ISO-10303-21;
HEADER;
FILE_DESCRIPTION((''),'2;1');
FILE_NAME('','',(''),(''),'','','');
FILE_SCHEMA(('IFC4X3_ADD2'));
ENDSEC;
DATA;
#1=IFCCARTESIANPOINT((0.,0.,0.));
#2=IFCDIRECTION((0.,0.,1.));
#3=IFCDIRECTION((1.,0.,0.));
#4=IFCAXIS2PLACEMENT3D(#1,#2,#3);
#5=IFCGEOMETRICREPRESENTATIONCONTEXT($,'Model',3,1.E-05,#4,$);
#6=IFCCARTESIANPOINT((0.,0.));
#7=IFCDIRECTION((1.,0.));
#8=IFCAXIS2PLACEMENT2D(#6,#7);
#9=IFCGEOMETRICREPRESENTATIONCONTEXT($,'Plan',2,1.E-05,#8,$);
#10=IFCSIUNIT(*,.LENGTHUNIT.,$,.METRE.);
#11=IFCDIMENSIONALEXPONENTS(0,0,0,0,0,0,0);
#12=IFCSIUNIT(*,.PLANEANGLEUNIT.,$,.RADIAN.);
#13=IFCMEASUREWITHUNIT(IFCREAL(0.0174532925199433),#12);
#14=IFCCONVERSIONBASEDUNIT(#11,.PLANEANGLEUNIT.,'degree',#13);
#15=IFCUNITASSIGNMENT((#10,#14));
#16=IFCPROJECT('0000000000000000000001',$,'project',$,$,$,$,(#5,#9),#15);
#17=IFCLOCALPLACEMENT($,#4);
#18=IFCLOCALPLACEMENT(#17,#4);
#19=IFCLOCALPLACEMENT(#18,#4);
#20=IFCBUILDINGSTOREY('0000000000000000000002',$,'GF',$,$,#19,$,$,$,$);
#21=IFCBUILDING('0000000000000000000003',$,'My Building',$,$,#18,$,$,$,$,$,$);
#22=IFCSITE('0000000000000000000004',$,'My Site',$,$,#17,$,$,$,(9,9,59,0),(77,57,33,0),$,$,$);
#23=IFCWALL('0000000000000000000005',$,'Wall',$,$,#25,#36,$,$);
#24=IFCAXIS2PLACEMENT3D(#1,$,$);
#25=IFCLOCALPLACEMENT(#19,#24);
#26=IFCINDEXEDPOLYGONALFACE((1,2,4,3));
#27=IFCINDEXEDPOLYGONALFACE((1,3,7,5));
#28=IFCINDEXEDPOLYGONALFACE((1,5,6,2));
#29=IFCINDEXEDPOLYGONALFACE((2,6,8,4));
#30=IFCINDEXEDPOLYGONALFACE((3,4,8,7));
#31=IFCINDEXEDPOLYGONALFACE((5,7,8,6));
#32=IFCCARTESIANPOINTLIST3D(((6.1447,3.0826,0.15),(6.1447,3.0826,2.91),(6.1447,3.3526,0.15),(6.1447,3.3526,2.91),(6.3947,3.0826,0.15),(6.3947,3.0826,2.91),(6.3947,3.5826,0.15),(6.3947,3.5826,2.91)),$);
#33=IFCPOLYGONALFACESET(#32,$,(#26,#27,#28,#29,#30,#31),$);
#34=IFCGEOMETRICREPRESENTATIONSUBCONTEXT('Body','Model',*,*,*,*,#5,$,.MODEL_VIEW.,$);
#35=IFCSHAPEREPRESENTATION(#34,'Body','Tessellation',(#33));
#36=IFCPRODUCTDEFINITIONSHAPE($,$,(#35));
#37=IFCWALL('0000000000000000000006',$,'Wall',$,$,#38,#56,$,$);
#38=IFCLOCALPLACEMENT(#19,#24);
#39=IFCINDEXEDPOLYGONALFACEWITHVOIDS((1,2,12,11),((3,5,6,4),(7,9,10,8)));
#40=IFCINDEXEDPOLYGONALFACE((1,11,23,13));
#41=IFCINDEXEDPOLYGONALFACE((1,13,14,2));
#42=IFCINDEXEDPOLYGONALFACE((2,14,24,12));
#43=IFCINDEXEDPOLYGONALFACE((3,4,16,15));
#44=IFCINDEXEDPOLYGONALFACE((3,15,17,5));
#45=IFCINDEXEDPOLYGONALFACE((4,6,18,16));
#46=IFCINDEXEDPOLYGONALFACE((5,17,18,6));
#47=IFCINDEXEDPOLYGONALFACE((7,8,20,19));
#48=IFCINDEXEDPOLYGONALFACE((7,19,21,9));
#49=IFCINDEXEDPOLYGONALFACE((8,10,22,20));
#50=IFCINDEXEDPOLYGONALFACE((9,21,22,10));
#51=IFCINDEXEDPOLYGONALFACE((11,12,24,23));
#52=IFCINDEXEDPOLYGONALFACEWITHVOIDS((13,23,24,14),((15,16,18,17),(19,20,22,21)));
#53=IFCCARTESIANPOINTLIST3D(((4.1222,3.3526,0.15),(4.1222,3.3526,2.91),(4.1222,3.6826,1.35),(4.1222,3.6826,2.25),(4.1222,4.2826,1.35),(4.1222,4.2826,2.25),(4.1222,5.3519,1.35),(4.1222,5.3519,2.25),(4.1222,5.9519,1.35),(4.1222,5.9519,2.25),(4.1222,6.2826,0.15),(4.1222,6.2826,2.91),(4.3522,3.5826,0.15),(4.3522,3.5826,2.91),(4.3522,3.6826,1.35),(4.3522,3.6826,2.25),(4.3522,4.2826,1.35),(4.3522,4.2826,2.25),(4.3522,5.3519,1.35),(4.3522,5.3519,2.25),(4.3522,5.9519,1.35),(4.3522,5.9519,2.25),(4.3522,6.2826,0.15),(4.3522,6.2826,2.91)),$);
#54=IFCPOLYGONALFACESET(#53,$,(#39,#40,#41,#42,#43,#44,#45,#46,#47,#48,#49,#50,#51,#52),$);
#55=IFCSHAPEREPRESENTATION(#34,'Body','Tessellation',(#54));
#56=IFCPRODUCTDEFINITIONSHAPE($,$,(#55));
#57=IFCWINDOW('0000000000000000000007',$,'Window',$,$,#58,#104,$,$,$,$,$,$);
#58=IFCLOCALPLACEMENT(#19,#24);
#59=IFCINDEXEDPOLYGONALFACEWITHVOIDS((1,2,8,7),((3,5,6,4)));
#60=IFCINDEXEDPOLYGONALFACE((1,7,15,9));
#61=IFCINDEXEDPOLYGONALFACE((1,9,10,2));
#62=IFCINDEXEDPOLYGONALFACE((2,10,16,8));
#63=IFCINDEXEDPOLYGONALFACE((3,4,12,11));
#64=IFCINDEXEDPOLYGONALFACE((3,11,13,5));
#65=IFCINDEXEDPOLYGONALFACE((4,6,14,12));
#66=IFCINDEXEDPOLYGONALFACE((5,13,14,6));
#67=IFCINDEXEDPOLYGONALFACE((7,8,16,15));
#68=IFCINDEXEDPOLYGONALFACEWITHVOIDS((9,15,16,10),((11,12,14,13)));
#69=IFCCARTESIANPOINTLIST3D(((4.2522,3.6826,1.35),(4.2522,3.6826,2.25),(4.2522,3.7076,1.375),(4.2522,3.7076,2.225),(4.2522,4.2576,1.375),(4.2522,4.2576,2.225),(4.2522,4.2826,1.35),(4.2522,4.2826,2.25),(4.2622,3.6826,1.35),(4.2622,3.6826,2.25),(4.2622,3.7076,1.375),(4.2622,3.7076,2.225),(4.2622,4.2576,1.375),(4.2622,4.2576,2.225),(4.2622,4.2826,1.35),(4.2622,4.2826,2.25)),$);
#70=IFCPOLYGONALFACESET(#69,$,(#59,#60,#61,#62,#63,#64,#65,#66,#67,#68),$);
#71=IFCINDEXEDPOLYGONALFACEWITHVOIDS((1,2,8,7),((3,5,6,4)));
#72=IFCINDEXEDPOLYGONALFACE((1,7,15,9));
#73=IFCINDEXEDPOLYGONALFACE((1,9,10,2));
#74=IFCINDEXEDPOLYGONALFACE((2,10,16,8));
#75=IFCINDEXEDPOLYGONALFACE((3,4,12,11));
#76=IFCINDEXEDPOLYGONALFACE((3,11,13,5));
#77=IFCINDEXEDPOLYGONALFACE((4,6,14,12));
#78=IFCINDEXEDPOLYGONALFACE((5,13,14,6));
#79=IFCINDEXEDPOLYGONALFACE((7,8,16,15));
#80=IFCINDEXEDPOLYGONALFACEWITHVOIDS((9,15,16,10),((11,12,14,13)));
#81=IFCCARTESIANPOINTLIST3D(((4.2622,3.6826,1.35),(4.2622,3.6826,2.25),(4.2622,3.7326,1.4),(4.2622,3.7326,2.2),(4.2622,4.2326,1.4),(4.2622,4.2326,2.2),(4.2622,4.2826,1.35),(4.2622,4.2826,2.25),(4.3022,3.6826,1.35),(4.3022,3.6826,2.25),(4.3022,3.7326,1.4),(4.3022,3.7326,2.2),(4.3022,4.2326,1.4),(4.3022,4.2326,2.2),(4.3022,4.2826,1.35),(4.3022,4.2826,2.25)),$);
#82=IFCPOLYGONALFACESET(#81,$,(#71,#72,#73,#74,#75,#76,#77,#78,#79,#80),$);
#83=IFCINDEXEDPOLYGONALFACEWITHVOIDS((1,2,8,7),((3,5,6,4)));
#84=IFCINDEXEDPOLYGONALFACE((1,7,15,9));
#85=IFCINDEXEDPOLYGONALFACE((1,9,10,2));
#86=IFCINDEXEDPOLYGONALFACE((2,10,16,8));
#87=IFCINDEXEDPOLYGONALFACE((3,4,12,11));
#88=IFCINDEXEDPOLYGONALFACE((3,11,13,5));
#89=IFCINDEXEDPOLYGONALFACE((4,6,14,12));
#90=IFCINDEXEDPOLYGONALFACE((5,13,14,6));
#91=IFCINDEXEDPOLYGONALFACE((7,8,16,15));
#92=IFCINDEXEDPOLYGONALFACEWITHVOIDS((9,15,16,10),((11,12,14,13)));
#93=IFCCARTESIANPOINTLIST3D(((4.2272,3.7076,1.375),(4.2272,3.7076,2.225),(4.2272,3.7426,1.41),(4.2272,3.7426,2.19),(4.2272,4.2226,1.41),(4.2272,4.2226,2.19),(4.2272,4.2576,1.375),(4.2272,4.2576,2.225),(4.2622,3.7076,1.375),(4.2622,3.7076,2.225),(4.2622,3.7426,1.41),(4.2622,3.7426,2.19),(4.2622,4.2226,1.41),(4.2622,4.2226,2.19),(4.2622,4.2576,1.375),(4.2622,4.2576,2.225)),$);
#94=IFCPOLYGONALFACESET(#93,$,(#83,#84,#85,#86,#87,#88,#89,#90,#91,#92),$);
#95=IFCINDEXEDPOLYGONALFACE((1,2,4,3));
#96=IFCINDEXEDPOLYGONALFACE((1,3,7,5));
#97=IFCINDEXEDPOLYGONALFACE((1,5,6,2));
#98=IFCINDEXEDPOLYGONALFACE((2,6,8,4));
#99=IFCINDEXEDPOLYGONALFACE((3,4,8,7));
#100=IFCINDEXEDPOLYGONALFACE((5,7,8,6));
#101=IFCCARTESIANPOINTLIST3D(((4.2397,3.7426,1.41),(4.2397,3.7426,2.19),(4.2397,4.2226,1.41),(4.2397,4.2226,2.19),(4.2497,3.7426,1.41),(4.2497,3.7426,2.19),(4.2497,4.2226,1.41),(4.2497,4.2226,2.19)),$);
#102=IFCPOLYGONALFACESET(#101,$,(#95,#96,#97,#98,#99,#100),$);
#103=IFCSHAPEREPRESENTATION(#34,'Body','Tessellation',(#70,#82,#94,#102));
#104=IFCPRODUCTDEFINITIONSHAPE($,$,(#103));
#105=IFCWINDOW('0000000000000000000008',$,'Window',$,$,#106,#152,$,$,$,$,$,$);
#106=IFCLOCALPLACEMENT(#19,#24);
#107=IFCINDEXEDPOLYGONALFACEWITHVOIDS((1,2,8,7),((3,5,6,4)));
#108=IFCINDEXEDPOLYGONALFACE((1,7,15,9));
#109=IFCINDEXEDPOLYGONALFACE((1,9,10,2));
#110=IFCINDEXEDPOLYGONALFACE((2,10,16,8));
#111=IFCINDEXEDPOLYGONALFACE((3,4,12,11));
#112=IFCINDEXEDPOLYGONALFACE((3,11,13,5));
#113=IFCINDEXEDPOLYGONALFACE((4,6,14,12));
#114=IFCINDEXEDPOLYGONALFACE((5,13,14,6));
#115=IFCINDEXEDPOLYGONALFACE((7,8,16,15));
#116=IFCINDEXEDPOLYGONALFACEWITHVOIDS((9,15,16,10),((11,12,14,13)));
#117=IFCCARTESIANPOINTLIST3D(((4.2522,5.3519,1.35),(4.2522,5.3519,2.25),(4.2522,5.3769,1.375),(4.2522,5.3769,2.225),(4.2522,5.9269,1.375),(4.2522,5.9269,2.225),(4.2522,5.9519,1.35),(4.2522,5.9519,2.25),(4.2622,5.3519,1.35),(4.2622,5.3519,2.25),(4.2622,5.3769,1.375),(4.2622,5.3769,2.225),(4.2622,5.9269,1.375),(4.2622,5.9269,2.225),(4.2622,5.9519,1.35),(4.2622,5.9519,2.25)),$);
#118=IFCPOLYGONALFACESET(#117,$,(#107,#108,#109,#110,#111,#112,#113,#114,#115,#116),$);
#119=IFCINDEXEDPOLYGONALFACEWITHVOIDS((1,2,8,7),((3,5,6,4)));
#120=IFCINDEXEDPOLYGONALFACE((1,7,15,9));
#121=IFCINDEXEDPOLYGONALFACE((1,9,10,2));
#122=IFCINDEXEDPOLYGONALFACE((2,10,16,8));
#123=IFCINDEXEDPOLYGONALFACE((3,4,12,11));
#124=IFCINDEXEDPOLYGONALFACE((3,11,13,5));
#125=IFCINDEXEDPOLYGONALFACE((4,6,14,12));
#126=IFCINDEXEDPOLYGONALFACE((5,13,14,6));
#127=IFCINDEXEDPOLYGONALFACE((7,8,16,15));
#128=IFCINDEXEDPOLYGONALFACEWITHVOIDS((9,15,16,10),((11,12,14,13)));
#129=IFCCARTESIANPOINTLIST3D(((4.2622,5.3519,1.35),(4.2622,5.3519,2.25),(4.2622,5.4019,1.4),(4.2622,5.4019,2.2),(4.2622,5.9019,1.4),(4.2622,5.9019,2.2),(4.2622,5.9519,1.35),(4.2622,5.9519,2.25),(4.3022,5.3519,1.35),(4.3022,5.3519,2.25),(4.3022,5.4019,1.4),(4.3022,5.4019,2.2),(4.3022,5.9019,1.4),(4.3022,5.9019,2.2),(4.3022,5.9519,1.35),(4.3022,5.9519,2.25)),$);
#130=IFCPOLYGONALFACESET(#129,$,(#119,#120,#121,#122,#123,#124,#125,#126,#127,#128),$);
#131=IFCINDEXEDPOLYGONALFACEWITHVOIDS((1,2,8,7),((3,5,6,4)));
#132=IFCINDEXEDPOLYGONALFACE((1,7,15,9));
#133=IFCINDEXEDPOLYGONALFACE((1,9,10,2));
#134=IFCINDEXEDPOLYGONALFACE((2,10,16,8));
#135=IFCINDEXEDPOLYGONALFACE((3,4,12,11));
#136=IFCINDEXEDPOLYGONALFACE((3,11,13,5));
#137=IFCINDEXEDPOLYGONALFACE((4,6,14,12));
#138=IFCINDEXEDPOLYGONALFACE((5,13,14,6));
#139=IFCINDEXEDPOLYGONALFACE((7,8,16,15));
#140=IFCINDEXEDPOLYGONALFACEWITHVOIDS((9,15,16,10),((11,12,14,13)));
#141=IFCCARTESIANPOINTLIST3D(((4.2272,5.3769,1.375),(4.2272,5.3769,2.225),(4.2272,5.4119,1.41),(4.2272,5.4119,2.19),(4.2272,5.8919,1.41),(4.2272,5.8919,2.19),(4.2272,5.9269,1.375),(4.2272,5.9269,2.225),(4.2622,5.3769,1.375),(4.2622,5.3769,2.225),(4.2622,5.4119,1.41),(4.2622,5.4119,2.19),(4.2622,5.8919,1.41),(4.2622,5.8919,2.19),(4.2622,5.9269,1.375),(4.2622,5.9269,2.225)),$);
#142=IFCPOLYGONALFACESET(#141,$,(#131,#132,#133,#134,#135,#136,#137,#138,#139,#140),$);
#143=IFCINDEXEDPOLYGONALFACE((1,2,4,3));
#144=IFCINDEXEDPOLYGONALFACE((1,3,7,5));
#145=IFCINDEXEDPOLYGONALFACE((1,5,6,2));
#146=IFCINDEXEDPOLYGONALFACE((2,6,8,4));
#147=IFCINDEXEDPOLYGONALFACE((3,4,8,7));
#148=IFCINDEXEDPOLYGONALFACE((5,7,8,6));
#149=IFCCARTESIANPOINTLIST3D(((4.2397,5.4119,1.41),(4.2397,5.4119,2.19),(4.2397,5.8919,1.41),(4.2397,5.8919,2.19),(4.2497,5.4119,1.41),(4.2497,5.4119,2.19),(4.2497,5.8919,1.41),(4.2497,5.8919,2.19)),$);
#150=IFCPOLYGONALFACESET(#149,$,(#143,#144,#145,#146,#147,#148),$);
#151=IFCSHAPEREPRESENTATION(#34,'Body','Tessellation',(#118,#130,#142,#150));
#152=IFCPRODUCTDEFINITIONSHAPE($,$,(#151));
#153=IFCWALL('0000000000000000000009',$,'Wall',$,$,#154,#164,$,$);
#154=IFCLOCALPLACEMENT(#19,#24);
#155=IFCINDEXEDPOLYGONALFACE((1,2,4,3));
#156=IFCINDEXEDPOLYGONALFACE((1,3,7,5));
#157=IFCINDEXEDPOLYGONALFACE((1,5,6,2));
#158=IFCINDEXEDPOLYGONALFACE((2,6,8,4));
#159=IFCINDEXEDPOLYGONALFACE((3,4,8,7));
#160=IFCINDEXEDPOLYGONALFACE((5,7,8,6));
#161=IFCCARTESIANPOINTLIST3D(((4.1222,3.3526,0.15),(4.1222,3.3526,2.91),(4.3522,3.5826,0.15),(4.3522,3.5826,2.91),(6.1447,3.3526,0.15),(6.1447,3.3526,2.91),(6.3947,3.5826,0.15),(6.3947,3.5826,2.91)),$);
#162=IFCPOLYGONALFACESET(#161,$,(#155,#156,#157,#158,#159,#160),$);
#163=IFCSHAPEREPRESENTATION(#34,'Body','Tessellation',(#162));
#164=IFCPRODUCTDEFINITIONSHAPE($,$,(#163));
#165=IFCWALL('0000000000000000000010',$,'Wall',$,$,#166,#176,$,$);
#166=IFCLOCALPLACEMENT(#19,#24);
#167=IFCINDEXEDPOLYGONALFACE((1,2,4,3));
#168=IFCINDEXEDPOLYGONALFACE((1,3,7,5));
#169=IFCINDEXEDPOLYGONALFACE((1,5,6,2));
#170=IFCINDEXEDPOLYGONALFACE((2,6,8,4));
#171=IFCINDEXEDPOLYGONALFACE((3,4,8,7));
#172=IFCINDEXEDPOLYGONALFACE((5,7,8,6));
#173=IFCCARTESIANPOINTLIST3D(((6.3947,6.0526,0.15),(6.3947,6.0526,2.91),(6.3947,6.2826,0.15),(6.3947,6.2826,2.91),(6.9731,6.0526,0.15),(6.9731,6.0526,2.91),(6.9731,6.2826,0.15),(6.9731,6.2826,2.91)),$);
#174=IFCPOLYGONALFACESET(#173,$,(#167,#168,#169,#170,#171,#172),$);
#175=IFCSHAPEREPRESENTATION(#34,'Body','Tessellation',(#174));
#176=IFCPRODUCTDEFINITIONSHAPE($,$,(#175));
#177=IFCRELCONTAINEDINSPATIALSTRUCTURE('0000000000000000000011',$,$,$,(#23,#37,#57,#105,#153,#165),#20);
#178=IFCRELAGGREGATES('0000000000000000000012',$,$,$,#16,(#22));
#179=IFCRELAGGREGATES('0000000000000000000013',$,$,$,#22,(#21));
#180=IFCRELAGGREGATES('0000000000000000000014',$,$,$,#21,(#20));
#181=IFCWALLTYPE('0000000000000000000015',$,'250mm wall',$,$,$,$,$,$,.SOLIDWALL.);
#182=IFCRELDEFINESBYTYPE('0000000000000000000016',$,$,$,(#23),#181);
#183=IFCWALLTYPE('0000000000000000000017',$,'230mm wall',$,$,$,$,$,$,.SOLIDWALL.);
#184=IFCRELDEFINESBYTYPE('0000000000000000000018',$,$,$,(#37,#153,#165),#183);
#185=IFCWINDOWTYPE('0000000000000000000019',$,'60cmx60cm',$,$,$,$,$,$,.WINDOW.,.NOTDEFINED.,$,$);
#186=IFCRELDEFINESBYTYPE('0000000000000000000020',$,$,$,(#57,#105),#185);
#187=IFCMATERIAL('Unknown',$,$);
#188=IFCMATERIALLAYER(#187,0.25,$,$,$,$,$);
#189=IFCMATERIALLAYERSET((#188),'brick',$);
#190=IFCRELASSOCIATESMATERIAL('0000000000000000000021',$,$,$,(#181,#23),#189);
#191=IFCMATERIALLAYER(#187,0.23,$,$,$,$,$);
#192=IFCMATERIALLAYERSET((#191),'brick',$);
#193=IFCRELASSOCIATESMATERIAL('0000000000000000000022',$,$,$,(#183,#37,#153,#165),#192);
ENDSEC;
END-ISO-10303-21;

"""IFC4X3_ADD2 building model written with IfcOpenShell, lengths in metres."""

from ifc_helpers import new_model, entity, si_unit, converted_unit, frame, origin_with_axes, origin_2d_with_axis, place, context, subcontext, project, spatial, line, indexed_curve, outline, extrude, shape, source, transform, mapped, material, layer, layer_set, layer_usage, type_object, type_shapes, element, fill, save


model = new_model("IFC4X3_ADD2")

# Units and contexts
model_context = context("Model", 3, precision=1e-05, world=origin_with_axes())
plan_context = context("Plan", 2, precision=1e-05, world=origin_2d_with_axis())
body_context_1 = subcontext(model_context, "Body", "Model", "MODEL_VIEW")
body_context_2 = subcontext(plan_context, "Body", "Plan", "PLAN_VIEW")
ifc_project = project(units=[si_unit("LENGTHUNIT", "METRE"), converted_unit("PLANEANGLEUNIT", "degree", entity("IfcReal", 0.0174532925199433), si_unit("PLANEANGLEUNIT", "RADIAN"), dimensions=[0, 0, 0, 0, 0, 0, 0])], contexts=[model_context, plan_context])

# Site, building, storey
site_placement = place(None, origin_with_axes())
site = spatial("IfcSite", under=ifc_project, at=site_placement, Name="My Site", RefLatitude=(9, 9, 59, 0), RefLongitude=(77, 57, 33, 0))
building_placement = place(site_placement, origin_with_axes())
building = spatial("IfcBuilding", under=site, at=building_placement, Name="My Building")
storey_placement = place(building_placement, origin_with_axes())
storey = spatial("IfcBuildingStorey", under=building, at=storey_placement, Name="GF")

# Wall
ifc_material_1 = material(Name="Unknown")
ifc_layer_1 = layer(ifc_material_1, 0.25)
ifc_layer_set_1 = layer_set([ifc_layer_1], Name="brick")
ifc_layer_usage_1 = layer_usage(ifc_layer_set_1, "AXIS2", "POSITIVE", 0.0)
wall_type_1 = type_object("IfcWallType", Name="250mm wall", PredefinedType="SOLIDWALL", material=ifc_layer_set_1)
wall_1_placement = place(storey_placement, frame((6.3947, 3.0826, 0.15), z_axis=(0.0, 0.0, 1.0), x_axis=(0.0, 1.0, 0.0)))
element("IfcWall", 1, at=wall_1_placement, inside=storey, type_object=wall_type_1, material=ifc_layer_usage_1, Name="Wall", context=body_context_1, shape_type="SweptSolid", body=[
    extrude(outline(indexed_curve([(0.0, 0.0), (0.0, 0.25), (0.27, 0.25), (0.5, 0.0)], segments=[line(1, 2, 3, 4, 1)])), origin_with_axes(), (0.0, 0.0, 1.0), 2.76),
])

# Wall, openings, windows
ifc_layer_2 = layer(ifc_material_1, 0.23)
ifc_layer_set_2 = layer_set([ifc_layer_2], Name="brick")
ifc_layer_usage_2 = layer_usage(ifc_layer_set_2, "AXIS2", "POSITIVE", 0.0)
wall_type_2 = type_object("IfcWallType", Name="230mm wall", PredefinedType="SOLIDWALL", material=ifc_layer_set_2)
wall_2_placement = place(storey_placement, frame((4.3522, 3.5826, 0.15), z_axis=(0.0, 0.0, 1.0), x_axis=(0.0, 1.0, 0.0)))
wall_2 = element("IfcWall", 2, at=wall_2_placement, inside=storey, type_object=wall_type_2, material=ifc_layer_usage_2, Name="Wall", context=body_context_1, shape_type="SweptSolid", body=[
    extrude(outline(indexed_curve([(0.0, 0.0), (-0.23, 0.23), (2.7, 0.23), (2.7, 0.0)], segments=[line(1, 2, 3, 4, 1)])), origin_with_axes(), (0.0, 0.0, 1.0), 2.76),
])
shared_shape_1 = source(origin_with_axes(), body_context_1, "Body", "SweptSolid", [
    extrude(outline(indexed_curve([(0.0, 0.0), (0.6, 0.0), (0.6, 0.9), (0.0, 0.9)], segments=[line(1, 2, 3, 4, 1)])), frame((0.0, -0.6, 0.0), z_axis=(0.0, -1.0, 0.0), x_axis=(1.0, 0.0, 0.0)), (0.0, 0.0, -1.0), 1.2),
])
opening_1_placement = place(wall_2_placement, frame((0.1, 0.0, 1.2), z_axis=(0.0, 0.0, 1.0), x_axis=(1.0, 0.0, 0.0)))
opening_1 = element("IfcOpeningElement", 3, at=opening_1_placement, cuts=wall_2, PredefinedType="OPENING", context=body_context_1, shape_type="MappedRepresentation", body=[
    mapped(shared_shape_1, transform((0.0, 0.0, 0.0), x_axis=(1.0, 0.0, 0.0), y_axis=(0.0, 1.0, 0.0), z_axis=(0.0, 0.0, 1.0), scale=1.0)),
])
opening_2_placement = place(wall_2_placement, frame((1.7693, 0.0, 1.2), z_axis=(0.0, 0.0, 1.0), x_axis=(1.0, 0.0, 0.0)))
opening_2 = element("IfcOpeningElement", 4, at=opening_2_placement, cuts=wall_2, PredefinedType="OPENING", context=body_context_1, shape_type="MappedRepresentation", body=[
    mapped(shared_shape_1, transform((0.0, 0.0, 0.0), x_axis=(1.0, 0.0, 0.0), y_axis=(0.0, 1.0, 0.0), z_axis=(0.0, 0.0, 1.0), scale=1.0)),
])
window_type = type_object("IfcWindowType", Name="60cmx60cm", PartitioningType="NOTDEFINED", PredefinedType="WINDOW")
shared_shape_2 = source(origin_with_axes(), body_context_1, "Body", "SweptSolid", [
    extrude(outline(indexed_curve([(0.0, 0.0), (0.6, 0.0), (0.6, 0.9), (0.0, 0.9)], segments=[line(1, 2, 3, 4, 1)]), holes=[indexed_curve([(0.025, 0.025), (0.575, 0.025), (0.575, 0.875), (0.025, 0.875)], segments=[line(1, 2, 3, 4, 1)])]), frame((0.0, 0.09, 0.0), z_axis=(0.0, -1.0, 0.0), x_axis=(1.0, 0.0, 0.0)), (0.0, 0.0, -1.0), 0.01),
    extrude(outline(indexed_curve([(0.0, 0.0), (0.6, 0.0), (0.6, 0.9), (0.0, 0.9)], segments=[line(1, 2, 3, 4, 1)]), holes=[indexed_curve([(0.05, 0.05), (0.55, 0.05), (0.55, 0.85), (0.05, 0.85)], segments=[line(1, 2, 3, 4, 1)])]), frame((0.0, 0.05, 0.0), z_axis=(0.0, -1.0, 0.0), x_axis=(1.0, 0.0, 0.0)), (0.0, 0.0, -1.0), 0.04),
    extrude(outline(indexed_curve([(0.0, 0.0), (0.55, 0.0), (0.55, 0.85), (0.0, 0.85)], segments=[line(1, 2, 3, 4, 1)]), holes=[indexed_curve([(0.035, 0.035), (0.515, 0.035), (0.515, 0.815), (0.035, 0.815)], segments=[line(1, 2, 3, 4, 1)])]), frame((0.025, 0.09, 0.025), z_axis=(0.0, -1.0, 0.0), x_axis=(1.0, 0.0, 0.0)), (0.0, 0.0, -1.0), 0.035),
    extrude(outline(indexed_curve([(0.035, 0.035), (0.515, 0.035), (0.515, 0.815), (0.035, 0.815)], segments=[line(1, 2, 3, 4, 1)])), frame((0.025, 0.1025, 0.025), z_axis=(0.0, -1.0, 0.0), x_axis=(1.0, 0.0, 0.0)), (0.0, 0.0, -1.0), 0.01),
])
shared_shape_3 = source(origin_with_axes(), body_context_2, "Body", "Curve2D", [
    entity("IfcIndexedPolyCurve", entity("IfcCartesianPointList2D", [[0.05, 0.05], [0.55, 0.05]])),
    entity("IfcIndexedPolyCurve", entity("IfcCartesianPointList2D", [[0.0, 0.1], [0.025, 0.1], [0.025, 0.09], [0.05, 0.09], [0.05, 0.05], [0.0, 0.05]]), [entity("IfcLineIndex", [1, 2, 3, 4, 5, 6, 1])]),
    entity("IfcIndexedPolyCurve", entity("IfcCartesianPointList2D", [[0.6, 0.1], [0.575, 0.1], [0.575, 0.09], [0.55, 0.09], [0.55, 0.05], [0.6, 0.05]]), [entity("IfcLineIndex", [1, 2, 3, 4, 5, 6, 1])]),
    entity("IfcIndexedPolyCurve", entity("IfcCartesianPointList2D", [[0.025, 0.09], [0.06, 0.09], [0.06, 0.125], [0.025, 0.125]]), [entity("IfcLineIndex", [1, 2, 3, 4, 1])]),
    entity("IfcIndexedPolyCurve", entity("IfcCartesianPointList2D", [[0.575, 0.09], [0.54, 0.09], [0.54, 0.125], [0.575, 0.125]]), [entity("IfcLineIndex", [1, 2, 3, 4, 1])]),
    entity("IfcIndexedPolyCurve", entity("IfcCartesianPointList2D", [[0.06, 0.09], [0.54, 0.09]])),
    entity("IfcIndexedPolyCurve", entity("IfcCartesianPointList2D", [[0.06, 0.125], [0.54, 0.125]])),
    entity("IfcIndexedPolyCurve", entity("IfcCartesianPointList2D", [[0.06, 0.1075], [0.54, 0.1075]])),
])
type_shapes(window_type, [shared_shape_2, shared_shape_3])
window_1_placement = place(opening_1_placement, frame((0.0, 0.0, 0.0), z_axis=(0.0, 0.0, 1.0), x_axis=(1.0, 0.0, 0.0)))
window_1 = element("IfcWindow", 5, at=window_1_placement, inside=storey, type_object=window_type, Name="Window", shapes=[
    shape(body_context_1, "Body", "MappedRepresentation", [mapped(shared_shape_2, transform((0.0, 0.0, 0.0), x_axis=(1.0, 0.0, 0.0), y_axis=(0.0, 1.0, 0.0), z_axis=(0.0, 0.0, 1.0), scale=1.0))]),
    shape(body_context_2, "Body", "MappedRepresentation", [mapped(shared_shape_3, transform((0.0, 0.0, 0.0), x_axis=(1.0, 0.0, 0.0), y_axis=(0.0, 1.0, 0.0), z_axis=(0.0, 0.0, 1.0), scale=1.0))]),
])
fill(opening_1, window_1)
window_2_placement = place(opening_2_placement, frame((0.0, 0.0, 0.0), z_axis=(0.0, 0.0, 1.0), x_axis=(1.0, 0.0, 0.0)))
window_2 = element("IfcWindow", 6, at=window_2_placement, inside=storey, type_object=window_type, Name="Window", shapes=[
    shape(body_context_1, "Body", "MappedRepresentation", [mapped(shared_shape_2, transform((0.0, 0.0, 0.0), x_axis=(1.0, 0.0, 0.0), y_axis=(0.0, 1.0, 0.0), z_axis=(0.0, 0.0, 1.0), scale=1.0))]),
    shape(body_context_2, "Body", "MappedRepresentation", [mapped(shared_shape_3, transform((0.0, 0.0, 0.0), x_axis=(1.0, 0.0, 0.0), y_axis=(0.0, 1.0, 0.0), z_axis=(0.0, 0.0, 1.0), scale=1.0))]),
])
fill(opening_2, window_2)

# Walls
ifc_layer_usage_3 = layer_usage(ifc_layer_set_2, "AXIS2", "POSITIVE", 0.0)
wall_3_placement = place(storey_placement, frame((6.3947, 3.5826, 0.15), z_axis=(0.0, 0.0, 1.0), x_axis=(-1.0, 0.0, 0.0)))
element("IfcWall", 7, at=wall_3_placement, inside=storey, type_object=wall_type_2, material=ifc_layer_usage_3, Name="Wall", context=body_context_1, shape_type="SweptSolid", body=[
    extrude(outline(indexed_curve([(0.0, 0.0), (0.25, 0.23), (2.2725, 0.23), (2.0425, 0.0)], segments=[line(1, 2, 3, 4, 1)])), origin_with_axes(), (0.0, 0.0, 1.0), 2.76),
])
ifc_layer_usage_4 = layer_usage(ifc_layer_set_2, "AXIS2", "POSITIVE", 0.0)
wall_4_placement = place(storey_placement, frame((6.3947, 6.0526, 0.15), z_axis=(0.0, 0.0, 1.0), x_axis=(1.0, 0.0, 0.0)))
element("IfcWall", 8, at=wall_4_placement, inside=storey, type_object=wall_type_2, material=ifc_layer_usage_4, Name="Wall", context=body_context_1, shape_type="SweptSolid", body=[
    extrude(outline(indexed_curve([(0.0, 0.0), (0.0, 0.23), (0.5785, 0.23), (0.5785, 0.0)], segments=[line(1, 2, 3, 4, 1)])), origin_with_axes(), (0.0, 0.0, 1.0), 2.76),
])

save(model, "model.ifc")
